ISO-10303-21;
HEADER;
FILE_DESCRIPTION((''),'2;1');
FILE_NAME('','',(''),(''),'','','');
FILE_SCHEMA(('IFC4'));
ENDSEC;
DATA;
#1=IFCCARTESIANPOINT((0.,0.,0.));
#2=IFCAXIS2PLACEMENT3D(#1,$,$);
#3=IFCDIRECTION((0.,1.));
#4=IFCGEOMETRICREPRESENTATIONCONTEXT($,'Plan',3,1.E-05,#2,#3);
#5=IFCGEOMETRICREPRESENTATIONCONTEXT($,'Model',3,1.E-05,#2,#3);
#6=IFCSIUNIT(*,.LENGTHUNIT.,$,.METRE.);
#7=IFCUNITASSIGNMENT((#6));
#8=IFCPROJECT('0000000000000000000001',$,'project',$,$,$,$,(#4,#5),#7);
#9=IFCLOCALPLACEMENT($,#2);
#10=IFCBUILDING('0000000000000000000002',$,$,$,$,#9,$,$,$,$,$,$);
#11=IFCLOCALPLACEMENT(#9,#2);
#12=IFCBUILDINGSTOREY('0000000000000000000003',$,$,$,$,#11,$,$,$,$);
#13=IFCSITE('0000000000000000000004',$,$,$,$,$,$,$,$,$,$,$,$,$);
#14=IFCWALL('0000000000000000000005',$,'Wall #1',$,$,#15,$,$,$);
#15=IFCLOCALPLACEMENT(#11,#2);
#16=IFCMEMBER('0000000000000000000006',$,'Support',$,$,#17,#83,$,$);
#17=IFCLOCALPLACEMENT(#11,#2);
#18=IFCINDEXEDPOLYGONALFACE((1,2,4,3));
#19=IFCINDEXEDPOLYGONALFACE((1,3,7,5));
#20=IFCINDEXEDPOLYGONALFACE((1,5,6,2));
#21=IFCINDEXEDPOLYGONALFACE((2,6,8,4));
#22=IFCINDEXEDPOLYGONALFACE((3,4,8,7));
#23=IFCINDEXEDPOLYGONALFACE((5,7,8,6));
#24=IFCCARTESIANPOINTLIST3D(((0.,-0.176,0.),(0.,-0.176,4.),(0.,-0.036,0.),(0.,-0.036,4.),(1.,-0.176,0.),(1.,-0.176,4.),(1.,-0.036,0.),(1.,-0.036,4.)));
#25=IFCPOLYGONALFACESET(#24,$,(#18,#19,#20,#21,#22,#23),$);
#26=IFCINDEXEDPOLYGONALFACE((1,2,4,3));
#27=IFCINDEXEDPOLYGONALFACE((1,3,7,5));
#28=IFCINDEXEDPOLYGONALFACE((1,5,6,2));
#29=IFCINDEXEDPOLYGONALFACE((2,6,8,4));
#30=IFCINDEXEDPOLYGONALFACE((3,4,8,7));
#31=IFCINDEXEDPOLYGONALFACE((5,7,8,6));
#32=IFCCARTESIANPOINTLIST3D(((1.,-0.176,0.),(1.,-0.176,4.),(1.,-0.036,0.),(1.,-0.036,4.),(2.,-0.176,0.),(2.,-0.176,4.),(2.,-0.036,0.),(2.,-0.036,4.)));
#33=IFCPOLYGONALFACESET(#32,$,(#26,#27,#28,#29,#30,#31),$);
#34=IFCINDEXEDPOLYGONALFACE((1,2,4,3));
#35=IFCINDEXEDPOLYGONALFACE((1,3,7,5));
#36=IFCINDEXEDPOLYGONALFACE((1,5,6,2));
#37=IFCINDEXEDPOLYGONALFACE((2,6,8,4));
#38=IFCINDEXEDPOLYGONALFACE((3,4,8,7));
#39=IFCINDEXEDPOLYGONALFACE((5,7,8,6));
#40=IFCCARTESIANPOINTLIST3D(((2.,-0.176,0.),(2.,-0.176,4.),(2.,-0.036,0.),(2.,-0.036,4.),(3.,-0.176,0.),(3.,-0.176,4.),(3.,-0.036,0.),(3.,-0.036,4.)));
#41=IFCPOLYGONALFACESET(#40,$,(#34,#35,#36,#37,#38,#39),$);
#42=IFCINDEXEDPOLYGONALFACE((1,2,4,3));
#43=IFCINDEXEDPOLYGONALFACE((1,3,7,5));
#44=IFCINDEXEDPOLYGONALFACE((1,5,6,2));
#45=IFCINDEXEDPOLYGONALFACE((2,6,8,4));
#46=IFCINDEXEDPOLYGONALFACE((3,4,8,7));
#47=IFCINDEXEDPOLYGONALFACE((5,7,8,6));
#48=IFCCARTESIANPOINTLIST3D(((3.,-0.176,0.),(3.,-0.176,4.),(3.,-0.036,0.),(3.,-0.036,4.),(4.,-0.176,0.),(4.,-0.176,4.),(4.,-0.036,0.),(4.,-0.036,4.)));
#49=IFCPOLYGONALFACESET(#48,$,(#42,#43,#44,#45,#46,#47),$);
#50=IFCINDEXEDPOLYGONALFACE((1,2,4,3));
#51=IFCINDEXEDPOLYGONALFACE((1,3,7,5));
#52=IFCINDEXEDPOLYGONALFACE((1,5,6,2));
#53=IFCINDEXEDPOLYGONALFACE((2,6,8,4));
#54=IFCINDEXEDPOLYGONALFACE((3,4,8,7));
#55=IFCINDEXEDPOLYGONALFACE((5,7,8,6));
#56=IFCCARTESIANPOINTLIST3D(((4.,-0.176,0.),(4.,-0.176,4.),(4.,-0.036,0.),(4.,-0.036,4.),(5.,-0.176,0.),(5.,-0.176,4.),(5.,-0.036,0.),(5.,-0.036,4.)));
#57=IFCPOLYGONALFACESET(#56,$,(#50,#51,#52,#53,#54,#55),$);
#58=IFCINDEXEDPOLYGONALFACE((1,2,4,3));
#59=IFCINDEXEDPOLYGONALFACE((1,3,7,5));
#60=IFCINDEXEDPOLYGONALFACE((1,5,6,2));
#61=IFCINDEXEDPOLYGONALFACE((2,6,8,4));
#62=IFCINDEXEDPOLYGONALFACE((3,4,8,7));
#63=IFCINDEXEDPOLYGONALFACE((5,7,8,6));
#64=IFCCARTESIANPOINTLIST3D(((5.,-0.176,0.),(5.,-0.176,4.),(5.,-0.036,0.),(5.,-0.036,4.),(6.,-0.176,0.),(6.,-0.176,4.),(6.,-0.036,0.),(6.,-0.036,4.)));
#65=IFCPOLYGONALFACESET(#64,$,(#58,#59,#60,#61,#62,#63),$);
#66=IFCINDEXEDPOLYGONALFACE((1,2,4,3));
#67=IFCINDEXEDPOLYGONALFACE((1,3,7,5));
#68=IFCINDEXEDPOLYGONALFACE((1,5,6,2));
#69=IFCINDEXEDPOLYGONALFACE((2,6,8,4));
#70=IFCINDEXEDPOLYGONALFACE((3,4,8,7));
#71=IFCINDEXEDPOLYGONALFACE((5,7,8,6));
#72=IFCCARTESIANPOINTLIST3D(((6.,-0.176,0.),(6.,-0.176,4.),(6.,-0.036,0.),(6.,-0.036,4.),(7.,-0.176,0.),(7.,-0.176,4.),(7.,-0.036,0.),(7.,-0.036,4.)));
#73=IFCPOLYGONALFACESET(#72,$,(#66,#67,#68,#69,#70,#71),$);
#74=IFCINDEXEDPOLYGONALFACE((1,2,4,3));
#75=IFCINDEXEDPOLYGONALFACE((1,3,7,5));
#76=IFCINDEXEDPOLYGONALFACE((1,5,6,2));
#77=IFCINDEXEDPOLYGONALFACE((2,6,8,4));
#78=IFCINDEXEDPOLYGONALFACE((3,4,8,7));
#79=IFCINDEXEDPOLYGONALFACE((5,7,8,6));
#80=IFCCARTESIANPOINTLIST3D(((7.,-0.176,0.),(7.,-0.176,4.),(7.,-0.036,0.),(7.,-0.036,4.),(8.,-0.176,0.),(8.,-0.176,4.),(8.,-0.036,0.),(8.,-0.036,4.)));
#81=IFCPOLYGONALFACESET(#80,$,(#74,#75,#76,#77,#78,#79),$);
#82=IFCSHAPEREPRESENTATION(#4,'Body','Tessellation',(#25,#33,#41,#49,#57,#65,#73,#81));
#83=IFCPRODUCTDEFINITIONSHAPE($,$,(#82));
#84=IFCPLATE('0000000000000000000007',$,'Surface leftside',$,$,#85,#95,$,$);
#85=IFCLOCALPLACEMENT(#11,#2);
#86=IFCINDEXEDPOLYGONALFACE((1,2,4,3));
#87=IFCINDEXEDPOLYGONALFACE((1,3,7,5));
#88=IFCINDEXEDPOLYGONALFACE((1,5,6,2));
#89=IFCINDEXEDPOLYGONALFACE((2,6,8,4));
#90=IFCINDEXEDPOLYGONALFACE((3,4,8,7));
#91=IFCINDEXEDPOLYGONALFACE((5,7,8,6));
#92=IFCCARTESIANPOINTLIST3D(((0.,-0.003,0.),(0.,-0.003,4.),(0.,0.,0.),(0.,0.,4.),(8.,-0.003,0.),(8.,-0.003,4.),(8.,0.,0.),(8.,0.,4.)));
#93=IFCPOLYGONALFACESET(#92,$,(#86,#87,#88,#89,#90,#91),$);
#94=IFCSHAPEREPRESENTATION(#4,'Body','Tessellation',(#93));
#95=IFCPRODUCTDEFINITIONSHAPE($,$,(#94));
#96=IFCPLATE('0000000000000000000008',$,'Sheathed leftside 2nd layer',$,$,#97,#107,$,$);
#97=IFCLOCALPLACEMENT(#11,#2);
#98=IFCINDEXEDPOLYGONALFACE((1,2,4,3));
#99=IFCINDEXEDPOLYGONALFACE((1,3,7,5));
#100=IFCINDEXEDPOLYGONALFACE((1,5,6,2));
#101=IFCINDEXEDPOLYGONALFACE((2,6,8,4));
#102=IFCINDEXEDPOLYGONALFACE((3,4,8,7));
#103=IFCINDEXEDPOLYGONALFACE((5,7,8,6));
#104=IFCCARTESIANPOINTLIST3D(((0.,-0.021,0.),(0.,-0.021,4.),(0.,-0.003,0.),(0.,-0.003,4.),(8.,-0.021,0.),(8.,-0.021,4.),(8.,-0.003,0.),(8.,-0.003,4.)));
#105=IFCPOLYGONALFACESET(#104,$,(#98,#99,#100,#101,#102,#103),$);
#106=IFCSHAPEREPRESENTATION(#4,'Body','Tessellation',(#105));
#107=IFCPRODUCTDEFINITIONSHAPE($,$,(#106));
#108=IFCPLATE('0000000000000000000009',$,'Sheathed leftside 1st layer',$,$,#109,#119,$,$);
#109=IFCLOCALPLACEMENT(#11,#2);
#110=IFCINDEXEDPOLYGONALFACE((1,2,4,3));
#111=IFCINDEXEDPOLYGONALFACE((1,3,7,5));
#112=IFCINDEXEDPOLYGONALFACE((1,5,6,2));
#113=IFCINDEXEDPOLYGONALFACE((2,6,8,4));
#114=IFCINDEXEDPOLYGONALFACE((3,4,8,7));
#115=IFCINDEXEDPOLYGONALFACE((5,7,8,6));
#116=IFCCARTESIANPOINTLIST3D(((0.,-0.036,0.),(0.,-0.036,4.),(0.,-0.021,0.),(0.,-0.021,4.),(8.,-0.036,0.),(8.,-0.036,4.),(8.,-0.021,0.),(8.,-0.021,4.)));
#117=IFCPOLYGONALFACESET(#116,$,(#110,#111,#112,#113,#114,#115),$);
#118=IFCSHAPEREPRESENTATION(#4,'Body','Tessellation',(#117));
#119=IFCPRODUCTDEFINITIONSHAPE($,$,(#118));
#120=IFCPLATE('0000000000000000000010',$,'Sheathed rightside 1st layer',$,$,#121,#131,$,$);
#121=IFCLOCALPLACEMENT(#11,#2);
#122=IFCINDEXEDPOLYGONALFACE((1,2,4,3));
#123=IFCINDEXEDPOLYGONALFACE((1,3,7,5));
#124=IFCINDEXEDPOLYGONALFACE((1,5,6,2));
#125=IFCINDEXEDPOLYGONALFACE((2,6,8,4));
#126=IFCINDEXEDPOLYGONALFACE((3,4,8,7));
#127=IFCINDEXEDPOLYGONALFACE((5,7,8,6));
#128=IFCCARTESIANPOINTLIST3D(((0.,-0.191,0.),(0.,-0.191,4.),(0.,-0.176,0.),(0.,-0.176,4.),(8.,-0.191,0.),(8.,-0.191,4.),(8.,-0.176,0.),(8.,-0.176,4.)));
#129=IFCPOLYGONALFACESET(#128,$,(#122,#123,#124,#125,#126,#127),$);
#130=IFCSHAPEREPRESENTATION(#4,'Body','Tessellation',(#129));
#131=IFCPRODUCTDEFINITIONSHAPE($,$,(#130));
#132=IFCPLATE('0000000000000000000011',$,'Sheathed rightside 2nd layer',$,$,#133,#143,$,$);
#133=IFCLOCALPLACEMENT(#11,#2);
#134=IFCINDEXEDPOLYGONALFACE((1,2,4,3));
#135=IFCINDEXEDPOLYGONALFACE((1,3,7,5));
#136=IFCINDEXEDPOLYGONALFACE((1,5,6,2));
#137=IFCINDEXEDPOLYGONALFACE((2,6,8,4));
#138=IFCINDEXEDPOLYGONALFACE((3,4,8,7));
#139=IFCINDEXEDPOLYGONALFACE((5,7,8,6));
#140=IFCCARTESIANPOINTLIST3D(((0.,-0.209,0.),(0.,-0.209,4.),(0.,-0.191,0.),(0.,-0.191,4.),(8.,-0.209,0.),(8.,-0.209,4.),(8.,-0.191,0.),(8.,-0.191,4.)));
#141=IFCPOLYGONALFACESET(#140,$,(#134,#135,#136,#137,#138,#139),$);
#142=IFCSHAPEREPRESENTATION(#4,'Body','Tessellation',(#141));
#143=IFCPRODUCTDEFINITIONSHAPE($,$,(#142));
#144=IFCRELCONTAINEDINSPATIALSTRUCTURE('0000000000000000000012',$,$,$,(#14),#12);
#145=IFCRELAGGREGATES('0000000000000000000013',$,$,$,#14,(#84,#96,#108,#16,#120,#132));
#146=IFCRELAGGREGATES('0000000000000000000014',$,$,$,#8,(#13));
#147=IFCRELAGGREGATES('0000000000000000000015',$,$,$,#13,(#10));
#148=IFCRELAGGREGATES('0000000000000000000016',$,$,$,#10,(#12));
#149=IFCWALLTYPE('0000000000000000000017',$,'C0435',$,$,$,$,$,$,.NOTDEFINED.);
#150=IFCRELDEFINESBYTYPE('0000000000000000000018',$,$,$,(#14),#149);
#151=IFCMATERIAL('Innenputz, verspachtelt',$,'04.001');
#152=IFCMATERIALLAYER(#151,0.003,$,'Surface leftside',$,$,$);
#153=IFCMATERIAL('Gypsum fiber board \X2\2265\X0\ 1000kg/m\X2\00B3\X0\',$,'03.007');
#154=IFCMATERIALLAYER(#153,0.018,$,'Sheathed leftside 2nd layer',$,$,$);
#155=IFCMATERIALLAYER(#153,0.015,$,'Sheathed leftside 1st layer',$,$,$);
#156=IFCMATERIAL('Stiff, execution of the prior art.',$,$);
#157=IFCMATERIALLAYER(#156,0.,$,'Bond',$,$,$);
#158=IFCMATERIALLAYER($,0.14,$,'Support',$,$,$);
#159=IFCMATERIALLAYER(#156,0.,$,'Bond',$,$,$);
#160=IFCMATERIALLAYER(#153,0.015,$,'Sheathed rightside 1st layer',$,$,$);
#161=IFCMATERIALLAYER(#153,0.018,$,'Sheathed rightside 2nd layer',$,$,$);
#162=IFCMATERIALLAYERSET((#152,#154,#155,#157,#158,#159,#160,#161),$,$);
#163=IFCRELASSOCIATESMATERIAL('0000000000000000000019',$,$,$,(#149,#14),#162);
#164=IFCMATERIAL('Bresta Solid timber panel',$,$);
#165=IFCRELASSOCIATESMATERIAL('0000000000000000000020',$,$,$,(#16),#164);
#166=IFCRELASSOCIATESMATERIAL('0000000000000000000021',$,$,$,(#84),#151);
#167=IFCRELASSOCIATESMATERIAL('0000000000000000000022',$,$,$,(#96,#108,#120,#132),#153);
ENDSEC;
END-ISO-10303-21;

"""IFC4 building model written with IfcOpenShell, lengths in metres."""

from ifc_helpers import new_model, si_unit, direction, frame, frame_2d, origin, origin_with_axes, place, context, project, spatial, rectangle, extrude, material, layer, layer_set, type_object, element, aggregate, save


model = new_model("IFC4")

# Units and contexts
plan_context = context("Plan", 3, precision=1e-05, world=origin(), true_north=direction((0.0, 1.0)))
model_context = context("Model", 3, precision=1e-05, world=origin(), true_north=direction((0.0, 1.0)))
ifc_project = project(units=[si_unit("LENGTHUNIT", "METRE")], contexts=[plan_context, model_context])

# Site, building, storey
site = spatial("IfcSite", under=ifc_project)
building_placement = place(None, origin())
building = spatial("IfcBuilding", under=site, at=building_placement)
storey_placement = place(building_placement, origin())
storey = spatial("IfcBuildingStorey", under=building, at=storey_placement)

# Wall, member, plates
ifc_material_1 = material(Name="Innenputz, verspachtelt", Category="04.001")
ifc_layer_1 = layer(ifc_material_1, 0.003, Name="Surface leftside")
ifc_material_2 = material(Name="Gypsum fiber board ≥ 1000kg/m³", Category="03.007")
ifc_layer_2 = layer(ifc_material_2, 0.018, Name="Sheathed leftside 2nd layer")
ifc_layer_3 = layer(ifc_material_2, 0.015, Name="Sheathed leftside 1st layer")
ifc_material_3 = material(Name="Stiff, execution of the prior art.")
ifc_layer_4 = layer(ifc_material_3, 0.0, Name="Bond")
ifc_layer_5 = layer(None, 0.14, Name="Support")
ifc_layer_6 = layer(ifc_material_3, 0.0, Name="Bond")
ifc_layer_7 = layer(ifc_material_2, 0.015, Name="Sheathed rightside 1st layer")
ifc_layer_8 = layer(ifc_material_2, 0.018, Name="Sheathed rightside 2nd layer")
ifc_layer_set = layer_set([ifc_layer_1, ifc_layer_2, ifc_layer_3, ifc_layer_4, ifc_layer_5, ifc_layer_6, ifc_layer_7, ifc_layer_8])
wall_type = type_object("IfcWallType", Name="C0435", PredefinedType="NOTDEFINED", material=ifc_layer_set)
wall_placement = place(None, frame((0.0, 0.0, 0.0), z_axis=(0.0, -1.0, 0.0), x_axis=(1.0, 0.0, 0.0)))
wall = element("IfcWall", 1, at=wall_placement, inside=storey, type_object=wall_type, material=ifc_layer_set, Name="Wall #1")
ifc_material_4 = material(Name="Bresta Solid timber panel")
member_placement = place(wall_placement, origin())
member = element("IfcMember", 2, at=member_placement, material=ifc_material_4, Name="Support", context=plan_context, shape_type="SweptSolid", body=[
    extrude(rectangle(XDim=1.0, YDim=0.14, at=frame_2d((0.5, 0.07), x_axis=(1.0, 0.0))), frame((0.0, 4.0, 0.036), z_axis=(0.0, -1.0, 0.0), x_axis=(1.0, 0.0, 0.0)), (0.0, 0.0, 1.0), 4.0),
    extrude(rectangle(XDim=1.0, YDim=0.14, at=frame_2d((0.5, 0.07), x_axis=(1.0, 0.0))), frame((1.0, 4.0, 0.036), z_axis=(0.0, -1.0, 0.0), x_axis=(1.0, 0.0, 0.0)), (0.0, 0.0, 1.0), 4.0),
    extrude(rectangle(XDim=1.0, YDim=0.14, at=frame_2d((0.5, 0.07), x_axis=(1.0, 0.0))), frame((2.0, 4.0, 0.036), z_axis=(0.0, -1.0, 0.0), x_axis=(1.0, 0.0, 0.0)), (0.0, 0.0, 1.0), 4.0),
    extrude(rectangle(XDim=1.0, YDim=0.14, at=frame_2d((0.5, 0.07), x_axis=(1.0, 0.0))), frame((3.0, 4.0, 0.036), z_axis=(0.0, -1.0, 0.0), x_axis=(1.0, 0.0, 0.0)), (0.0, 0.0, 1.0), 4.0),
    extrude(rectangle(XDim=1.0, YDim=0.14, at=frame_2d((0.5, 0.07), x_axis=(1.0, 0.0))), frame((4.0, 4.0, 0.036), z_axis=(0.0, -1.0, 0.0), x_axis=(1.0, 0.0, 0.0)), (0.0, 0.0, 1.0), 4.0),
    extrude(rectangle(XDim=1.0, YDim=0.14, at=frame_2d((0.5, 0.07), x_axis=(1.0, 0.0))), frame((5.0, 4.0, 0.036), z_axis=(0.0, -1.0, 0.0), x_axis=(1.0, 0.0, 0.0)), (0.0, 0.0, 1.0), 4.0),
    extrude(rectangle(XDim=1.0, YDim=0.14, at=frame_2d((0.5, 0.07), x_axis=(1.0, 0.0))), frame((6.0, 4.0, 0.036), z_axis=(0.0, -1.0, 0.0), x_axis=(1.0, 0.0, 0.0)), (0.0, 0.0, 1.0), 4.0),
    extrude(rectangle(XDim=1.0, YDim=0.14, at=frame_2d((0.5, 0.07), x_axis=(1.0, 0.0))), frame((7.0, 4.0, 0.036), z_axis=(0.0, -1.0, 0.0), x_axis=(1.0, 0.0, 0.0)), (0.0, 0.0, 1.0), 4.0),
])
plate_1_placement = place(wall_placement, origin())
plate_1 = element("IfcPlate", 3, at=plate_1_placement, material=ifc_material_1, Name="Surface leftside", context=plan_context, shape_type="SweptSolid", body=[
    extrude(rectangle(XDim=8.0, YDim=4.0, at=frame_2d((4.0, 2.0), x_axis=(1.0, 0.0))), origin_with_axes(), (0.0, 0.0, 1.0), 0.003),
])
plate_2_placement = place(wall_placement, origin())
plate_2 = element("IfcPlate", 4, at=plate_2_placement, material=ifc_material_2, Name="Sheathed leftside 2nd layer", context=plan_context, shape_type="SweptSolid", body=[
    extrude(rectangle(XDim=8.0, YDim=4.0, at=frame_2d((4.0, 2.0), x_axis=(1.0, 0.0))), frame((0.0, 0.0, 0.003), z_axis=(0.0, 0.0, 1.0), x_axis=(1.0, 0.0, 0.0)), (0.0, 0.0, 1.0), 0.018),
])
plate_3_placement = place(wall_placement, origin())
plate_3 = element("IfcPlate", 5, at=plate_3_placement, material=ifc_material_2, Name="Sheathed leftside 1st layer", context=plan_context, shape_type="SweptSolid", body=[
    extrude(rectangle(XDim=8.0, YDim=4.0, at=frame_2d((4.0, 2.0), x_axis=(1.0, 0.0))), frame((0.0, 0.0, 0.021), z_axis=(0.0, 0.0, 1.0), x_axis=(1.0, 0.0, 0.0)), (0.0, 0.0, 1.0), 0.015),
])
plate_4_placement = place(wall_placement, origin())
plate_4 = element("IfcPlate", 6, at=plate_4_placement, material=ifc_material_2, Name="Sheathed rightside 1st layer", context=plan_context, shape_type="SweptSolid", body=[
    extrude(rectangle(XDim=8.0, YDim=4.0, at=frame_2d((4.0, 2.0), x_axis=(1.0, 0.0))), frame((0.0, 0.0, 0.176), z_axis=(0.0, 0.0, 1.0), x_axis=(1.0, 0.0, 0.0)), (0.0, 0.0, 1.0), 0.015),
])
plate_5_placement = place(wall_placement, origin())
plate_5 = element("IfcPlate", 7, at=plate_5_placement, material=ifc_material_2, Name="Sheathed rightside 2nd layer", context=plan_context, shape_type="SweptSolid", body=[
    extrude(rectangle(XDim=8.0, YDim=4.0, at=frame_2d((4.0, 2.0), x_axis=(1.0, 0.0))), frame((0.0, 0.0, 0.191), z_axis=(0.0, 0.0, 1.0), x_axis=(1.0, 0.0, 0.0)), (0.0, 0.0, 1.0), 0.018),
])
aggregate(wall, [plate_1, plate_2, plate_3, member, plate_4, plate_5])

save(model, "model.ifc")
